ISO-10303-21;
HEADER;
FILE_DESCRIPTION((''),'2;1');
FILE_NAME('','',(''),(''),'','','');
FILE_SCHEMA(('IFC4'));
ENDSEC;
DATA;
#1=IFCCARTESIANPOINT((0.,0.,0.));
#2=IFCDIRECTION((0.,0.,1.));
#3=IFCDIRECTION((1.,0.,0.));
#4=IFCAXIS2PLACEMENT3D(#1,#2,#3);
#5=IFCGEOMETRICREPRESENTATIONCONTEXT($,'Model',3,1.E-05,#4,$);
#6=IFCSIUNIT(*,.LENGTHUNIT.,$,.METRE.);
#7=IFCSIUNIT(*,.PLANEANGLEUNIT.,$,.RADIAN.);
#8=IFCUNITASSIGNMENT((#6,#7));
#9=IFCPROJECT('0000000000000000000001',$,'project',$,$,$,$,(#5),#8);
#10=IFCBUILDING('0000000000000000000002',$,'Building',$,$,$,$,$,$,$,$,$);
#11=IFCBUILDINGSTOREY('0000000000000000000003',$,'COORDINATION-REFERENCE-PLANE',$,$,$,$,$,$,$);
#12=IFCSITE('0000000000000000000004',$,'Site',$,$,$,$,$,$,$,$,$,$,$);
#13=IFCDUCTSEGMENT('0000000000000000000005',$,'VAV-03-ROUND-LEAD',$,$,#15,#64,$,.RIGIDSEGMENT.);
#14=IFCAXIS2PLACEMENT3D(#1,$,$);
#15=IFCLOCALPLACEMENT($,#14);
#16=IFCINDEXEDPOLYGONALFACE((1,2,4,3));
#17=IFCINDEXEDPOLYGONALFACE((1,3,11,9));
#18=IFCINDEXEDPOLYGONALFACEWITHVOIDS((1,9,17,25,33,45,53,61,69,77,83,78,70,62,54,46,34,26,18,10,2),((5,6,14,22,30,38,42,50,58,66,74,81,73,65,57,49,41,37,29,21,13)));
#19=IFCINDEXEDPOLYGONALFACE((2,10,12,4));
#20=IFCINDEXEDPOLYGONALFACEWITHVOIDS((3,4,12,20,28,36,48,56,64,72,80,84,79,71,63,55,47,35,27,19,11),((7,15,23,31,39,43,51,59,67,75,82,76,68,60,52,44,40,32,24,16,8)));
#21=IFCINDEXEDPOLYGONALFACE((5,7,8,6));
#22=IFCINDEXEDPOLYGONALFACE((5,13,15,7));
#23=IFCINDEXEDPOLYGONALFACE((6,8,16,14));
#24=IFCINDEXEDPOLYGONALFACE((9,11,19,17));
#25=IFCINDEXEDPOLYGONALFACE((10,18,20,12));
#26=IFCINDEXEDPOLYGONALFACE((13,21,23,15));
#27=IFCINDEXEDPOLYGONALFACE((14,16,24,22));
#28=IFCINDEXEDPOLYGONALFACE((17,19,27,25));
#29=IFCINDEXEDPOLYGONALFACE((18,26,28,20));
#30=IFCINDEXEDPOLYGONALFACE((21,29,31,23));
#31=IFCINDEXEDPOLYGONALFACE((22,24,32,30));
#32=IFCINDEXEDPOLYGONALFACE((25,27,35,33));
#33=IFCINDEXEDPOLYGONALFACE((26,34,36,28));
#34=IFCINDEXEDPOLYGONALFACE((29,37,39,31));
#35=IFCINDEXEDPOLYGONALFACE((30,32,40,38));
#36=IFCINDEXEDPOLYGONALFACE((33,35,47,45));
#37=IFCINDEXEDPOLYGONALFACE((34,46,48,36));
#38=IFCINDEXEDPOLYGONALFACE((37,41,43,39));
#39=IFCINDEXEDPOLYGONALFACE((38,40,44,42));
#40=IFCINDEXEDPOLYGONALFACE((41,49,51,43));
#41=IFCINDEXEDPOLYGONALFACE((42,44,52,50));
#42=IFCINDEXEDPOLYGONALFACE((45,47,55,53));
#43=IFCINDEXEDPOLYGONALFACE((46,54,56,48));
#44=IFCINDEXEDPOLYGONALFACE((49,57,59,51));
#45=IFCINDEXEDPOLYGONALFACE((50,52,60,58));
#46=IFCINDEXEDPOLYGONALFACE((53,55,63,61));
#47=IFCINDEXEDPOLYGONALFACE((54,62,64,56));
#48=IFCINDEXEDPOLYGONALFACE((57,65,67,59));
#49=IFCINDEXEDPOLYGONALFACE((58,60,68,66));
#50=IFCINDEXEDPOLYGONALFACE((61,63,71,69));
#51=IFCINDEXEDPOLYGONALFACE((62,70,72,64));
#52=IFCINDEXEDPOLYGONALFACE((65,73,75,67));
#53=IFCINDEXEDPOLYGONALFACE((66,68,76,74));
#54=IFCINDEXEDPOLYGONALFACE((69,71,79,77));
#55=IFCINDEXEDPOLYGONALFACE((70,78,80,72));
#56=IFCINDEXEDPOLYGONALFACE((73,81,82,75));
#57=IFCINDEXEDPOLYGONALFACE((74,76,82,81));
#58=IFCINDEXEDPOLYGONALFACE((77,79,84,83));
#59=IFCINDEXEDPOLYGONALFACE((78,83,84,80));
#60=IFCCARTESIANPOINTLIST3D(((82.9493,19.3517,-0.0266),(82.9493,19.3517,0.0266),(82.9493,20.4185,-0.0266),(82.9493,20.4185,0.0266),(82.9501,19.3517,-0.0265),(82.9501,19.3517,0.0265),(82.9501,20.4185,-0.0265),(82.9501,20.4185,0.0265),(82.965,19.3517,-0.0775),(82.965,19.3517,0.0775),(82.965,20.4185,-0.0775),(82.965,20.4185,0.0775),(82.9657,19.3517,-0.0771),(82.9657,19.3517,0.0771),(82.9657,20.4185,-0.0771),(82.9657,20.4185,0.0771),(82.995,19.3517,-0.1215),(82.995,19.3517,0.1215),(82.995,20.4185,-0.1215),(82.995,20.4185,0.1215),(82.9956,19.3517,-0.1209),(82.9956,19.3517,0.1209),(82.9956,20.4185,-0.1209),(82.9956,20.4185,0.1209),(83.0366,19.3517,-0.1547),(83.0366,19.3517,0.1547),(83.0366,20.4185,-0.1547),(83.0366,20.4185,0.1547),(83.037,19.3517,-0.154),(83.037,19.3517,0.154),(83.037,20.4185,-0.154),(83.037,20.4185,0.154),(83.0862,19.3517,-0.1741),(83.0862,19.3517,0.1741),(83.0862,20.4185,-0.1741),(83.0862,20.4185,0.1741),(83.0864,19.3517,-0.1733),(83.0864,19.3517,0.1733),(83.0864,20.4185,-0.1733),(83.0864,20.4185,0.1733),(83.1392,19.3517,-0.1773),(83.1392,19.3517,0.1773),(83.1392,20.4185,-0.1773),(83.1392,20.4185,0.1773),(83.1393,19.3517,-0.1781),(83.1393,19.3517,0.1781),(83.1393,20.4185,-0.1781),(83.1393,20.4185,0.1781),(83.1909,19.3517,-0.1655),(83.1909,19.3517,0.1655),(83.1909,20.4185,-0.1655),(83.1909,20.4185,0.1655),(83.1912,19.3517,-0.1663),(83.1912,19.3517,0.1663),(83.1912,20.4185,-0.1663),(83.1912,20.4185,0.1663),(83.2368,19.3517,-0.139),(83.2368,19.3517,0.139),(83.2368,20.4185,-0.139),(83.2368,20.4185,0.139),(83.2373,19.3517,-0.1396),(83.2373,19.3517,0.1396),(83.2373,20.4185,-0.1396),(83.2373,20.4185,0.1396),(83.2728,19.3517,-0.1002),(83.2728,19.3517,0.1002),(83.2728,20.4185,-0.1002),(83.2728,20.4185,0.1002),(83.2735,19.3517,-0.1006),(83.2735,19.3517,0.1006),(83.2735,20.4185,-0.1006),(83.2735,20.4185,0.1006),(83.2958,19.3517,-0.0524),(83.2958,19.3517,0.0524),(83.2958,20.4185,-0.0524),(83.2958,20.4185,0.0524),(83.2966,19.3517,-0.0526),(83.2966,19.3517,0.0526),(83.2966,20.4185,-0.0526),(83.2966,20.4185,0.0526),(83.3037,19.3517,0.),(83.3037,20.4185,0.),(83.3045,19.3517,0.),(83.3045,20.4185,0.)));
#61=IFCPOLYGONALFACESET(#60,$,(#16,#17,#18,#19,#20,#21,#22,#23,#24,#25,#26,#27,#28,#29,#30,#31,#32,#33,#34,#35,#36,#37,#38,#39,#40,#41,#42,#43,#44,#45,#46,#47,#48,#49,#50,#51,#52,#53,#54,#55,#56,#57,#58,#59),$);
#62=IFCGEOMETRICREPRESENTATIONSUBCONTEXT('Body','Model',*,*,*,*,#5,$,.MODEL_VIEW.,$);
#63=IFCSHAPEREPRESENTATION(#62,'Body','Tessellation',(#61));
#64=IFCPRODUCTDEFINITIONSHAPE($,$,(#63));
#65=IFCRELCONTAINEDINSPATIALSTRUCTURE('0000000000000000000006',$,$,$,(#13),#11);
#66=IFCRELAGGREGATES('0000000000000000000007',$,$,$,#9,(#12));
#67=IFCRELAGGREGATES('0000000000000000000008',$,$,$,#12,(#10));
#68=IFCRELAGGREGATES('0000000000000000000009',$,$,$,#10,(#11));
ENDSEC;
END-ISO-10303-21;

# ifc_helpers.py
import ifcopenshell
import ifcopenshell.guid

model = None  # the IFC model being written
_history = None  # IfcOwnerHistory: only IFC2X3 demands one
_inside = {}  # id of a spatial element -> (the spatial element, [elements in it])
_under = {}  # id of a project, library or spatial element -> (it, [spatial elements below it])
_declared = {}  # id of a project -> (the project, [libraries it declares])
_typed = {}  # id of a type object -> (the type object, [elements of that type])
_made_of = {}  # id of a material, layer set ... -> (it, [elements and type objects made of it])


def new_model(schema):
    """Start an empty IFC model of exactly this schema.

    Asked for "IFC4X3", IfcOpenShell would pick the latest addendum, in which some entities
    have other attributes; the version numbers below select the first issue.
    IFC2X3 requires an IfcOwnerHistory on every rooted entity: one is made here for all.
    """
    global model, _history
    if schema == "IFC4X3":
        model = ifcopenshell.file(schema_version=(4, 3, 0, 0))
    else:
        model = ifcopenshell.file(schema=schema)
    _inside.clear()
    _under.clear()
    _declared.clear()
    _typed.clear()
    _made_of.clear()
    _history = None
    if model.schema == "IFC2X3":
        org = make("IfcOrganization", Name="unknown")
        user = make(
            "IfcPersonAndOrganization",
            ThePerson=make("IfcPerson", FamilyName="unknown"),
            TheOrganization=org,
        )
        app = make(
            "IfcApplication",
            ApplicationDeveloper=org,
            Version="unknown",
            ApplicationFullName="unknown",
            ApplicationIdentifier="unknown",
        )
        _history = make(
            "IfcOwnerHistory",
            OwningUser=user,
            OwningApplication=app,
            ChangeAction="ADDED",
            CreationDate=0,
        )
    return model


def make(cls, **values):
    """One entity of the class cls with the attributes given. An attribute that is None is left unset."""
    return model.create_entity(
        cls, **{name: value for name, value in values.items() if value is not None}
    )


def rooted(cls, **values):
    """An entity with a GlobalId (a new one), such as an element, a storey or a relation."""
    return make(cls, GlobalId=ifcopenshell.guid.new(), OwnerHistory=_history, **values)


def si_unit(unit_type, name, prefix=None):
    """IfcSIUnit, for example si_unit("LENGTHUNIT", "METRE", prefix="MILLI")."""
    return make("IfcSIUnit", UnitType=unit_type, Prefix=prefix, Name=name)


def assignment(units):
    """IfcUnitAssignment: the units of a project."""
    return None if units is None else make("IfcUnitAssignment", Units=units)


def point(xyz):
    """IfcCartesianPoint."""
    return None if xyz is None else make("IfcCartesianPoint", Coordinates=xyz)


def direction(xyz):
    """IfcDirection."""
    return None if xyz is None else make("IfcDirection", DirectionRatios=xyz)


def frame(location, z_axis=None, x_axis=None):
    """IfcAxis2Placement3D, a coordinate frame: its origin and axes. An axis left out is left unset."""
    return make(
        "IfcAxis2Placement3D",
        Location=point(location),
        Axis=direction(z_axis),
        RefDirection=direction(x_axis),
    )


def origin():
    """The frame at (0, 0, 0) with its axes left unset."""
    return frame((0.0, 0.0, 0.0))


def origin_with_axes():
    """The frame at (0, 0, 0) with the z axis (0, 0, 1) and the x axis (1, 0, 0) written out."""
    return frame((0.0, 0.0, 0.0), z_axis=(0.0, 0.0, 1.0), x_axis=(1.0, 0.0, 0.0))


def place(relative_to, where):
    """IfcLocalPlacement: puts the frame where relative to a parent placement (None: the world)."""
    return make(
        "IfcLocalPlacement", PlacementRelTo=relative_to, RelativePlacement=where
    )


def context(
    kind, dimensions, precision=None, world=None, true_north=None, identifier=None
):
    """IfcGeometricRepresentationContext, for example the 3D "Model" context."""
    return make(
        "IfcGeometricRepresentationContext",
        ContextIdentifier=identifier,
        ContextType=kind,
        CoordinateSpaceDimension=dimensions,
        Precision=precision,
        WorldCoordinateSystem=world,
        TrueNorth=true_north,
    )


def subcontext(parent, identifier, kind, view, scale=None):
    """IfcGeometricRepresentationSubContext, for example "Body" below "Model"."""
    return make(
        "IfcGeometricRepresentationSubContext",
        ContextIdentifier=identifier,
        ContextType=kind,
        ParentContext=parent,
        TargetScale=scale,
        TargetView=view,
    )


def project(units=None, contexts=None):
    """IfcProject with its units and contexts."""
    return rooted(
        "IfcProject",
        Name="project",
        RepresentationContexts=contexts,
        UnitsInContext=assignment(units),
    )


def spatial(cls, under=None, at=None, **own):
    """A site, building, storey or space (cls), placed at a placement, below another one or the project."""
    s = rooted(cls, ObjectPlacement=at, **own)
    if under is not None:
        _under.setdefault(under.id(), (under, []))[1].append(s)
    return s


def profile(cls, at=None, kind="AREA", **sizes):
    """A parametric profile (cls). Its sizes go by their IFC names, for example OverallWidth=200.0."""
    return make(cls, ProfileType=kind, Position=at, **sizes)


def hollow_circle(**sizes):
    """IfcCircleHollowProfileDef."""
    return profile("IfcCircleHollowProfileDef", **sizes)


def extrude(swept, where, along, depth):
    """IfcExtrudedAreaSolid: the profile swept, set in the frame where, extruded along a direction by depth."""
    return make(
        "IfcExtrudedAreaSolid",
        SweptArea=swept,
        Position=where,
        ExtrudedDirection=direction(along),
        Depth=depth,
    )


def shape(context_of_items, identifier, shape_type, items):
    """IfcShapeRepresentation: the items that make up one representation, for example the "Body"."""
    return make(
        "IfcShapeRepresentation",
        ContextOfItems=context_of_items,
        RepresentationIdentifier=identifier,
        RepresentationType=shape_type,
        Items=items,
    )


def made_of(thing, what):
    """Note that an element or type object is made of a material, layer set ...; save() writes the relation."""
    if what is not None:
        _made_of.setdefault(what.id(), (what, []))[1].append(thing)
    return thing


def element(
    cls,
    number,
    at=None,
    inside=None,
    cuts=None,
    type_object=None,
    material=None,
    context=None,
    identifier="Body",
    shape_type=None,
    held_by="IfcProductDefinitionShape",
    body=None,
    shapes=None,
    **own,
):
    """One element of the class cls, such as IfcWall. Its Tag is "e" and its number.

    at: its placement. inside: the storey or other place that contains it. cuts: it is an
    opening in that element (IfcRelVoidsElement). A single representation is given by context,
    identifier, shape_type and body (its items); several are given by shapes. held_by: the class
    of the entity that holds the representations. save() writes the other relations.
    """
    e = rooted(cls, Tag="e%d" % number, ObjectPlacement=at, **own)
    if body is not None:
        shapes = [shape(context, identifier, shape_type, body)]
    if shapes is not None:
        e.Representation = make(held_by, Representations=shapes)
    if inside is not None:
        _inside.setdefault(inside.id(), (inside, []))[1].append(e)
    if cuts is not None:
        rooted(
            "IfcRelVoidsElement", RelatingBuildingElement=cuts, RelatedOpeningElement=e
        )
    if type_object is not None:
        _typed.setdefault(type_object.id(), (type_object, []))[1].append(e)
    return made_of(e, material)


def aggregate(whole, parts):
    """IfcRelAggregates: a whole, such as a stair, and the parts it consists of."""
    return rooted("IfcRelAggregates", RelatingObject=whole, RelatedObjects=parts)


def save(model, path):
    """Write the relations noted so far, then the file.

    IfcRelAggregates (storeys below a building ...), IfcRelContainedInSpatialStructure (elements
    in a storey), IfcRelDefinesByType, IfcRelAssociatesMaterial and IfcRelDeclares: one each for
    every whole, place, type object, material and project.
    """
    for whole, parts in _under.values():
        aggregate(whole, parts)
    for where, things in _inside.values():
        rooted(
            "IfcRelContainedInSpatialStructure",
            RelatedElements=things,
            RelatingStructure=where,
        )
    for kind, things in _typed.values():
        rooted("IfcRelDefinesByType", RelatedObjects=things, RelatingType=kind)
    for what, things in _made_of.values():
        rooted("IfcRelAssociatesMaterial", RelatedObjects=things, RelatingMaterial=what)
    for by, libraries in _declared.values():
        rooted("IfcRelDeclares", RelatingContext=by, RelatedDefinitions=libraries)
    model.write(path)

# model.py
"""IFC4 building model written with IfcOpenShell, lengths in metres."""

from ifc_helpers import new_model, si_unit, frame, origin, origin_with_axes, place, context, subcontext, project, spatial, hollow_circle, extrude, element, save


model = new_model("IFC4")

# Units and contexts
model_context = context("Model", 3, precision=1e-05, world=origin_with_axes())
body_context_1 = subcontext(model_context, "Body", "Model", "MODEL_VIEW")
ifc_project = project(units=[si_unit("LENGTHUNIT", "METRE"), si_unit("PLANEANGLEUNIT", "RADIAN")], contexts=[model_context])

# Site, building, storey
site = spatial("IfcSite", under=ifc_project, Name="Site")
building = spatial("IfcBuilding", under=site, Name="Building")
storey = spatial("IfcBuildingStorey", under=building, Name="COORDINATION-REFERENCE-PLANE")

# Duct segment
duct_segment_1_placement = place(None, frame((83.1259, 20.4185, 0.0), z_axis=(0.0, -1.0, 0.0), x_axis=(1.0, 0.0, 0.0)))
element("IfcDuctSegment", 1, at=duct_segment_1_placement, inside=storey, Name="VAV-03-ROUND-LEAD", PredefinedType="RIGIDSEGMENT", context=body_context_1, shape_type="SweptSolid", body=[
    extrude(hollow_circle(Radius=0.1786, WallThickness=0.0008), origin(), (0.0, 0.0, 1.0), 1.0668),
])

save(model, "model.ifc")
